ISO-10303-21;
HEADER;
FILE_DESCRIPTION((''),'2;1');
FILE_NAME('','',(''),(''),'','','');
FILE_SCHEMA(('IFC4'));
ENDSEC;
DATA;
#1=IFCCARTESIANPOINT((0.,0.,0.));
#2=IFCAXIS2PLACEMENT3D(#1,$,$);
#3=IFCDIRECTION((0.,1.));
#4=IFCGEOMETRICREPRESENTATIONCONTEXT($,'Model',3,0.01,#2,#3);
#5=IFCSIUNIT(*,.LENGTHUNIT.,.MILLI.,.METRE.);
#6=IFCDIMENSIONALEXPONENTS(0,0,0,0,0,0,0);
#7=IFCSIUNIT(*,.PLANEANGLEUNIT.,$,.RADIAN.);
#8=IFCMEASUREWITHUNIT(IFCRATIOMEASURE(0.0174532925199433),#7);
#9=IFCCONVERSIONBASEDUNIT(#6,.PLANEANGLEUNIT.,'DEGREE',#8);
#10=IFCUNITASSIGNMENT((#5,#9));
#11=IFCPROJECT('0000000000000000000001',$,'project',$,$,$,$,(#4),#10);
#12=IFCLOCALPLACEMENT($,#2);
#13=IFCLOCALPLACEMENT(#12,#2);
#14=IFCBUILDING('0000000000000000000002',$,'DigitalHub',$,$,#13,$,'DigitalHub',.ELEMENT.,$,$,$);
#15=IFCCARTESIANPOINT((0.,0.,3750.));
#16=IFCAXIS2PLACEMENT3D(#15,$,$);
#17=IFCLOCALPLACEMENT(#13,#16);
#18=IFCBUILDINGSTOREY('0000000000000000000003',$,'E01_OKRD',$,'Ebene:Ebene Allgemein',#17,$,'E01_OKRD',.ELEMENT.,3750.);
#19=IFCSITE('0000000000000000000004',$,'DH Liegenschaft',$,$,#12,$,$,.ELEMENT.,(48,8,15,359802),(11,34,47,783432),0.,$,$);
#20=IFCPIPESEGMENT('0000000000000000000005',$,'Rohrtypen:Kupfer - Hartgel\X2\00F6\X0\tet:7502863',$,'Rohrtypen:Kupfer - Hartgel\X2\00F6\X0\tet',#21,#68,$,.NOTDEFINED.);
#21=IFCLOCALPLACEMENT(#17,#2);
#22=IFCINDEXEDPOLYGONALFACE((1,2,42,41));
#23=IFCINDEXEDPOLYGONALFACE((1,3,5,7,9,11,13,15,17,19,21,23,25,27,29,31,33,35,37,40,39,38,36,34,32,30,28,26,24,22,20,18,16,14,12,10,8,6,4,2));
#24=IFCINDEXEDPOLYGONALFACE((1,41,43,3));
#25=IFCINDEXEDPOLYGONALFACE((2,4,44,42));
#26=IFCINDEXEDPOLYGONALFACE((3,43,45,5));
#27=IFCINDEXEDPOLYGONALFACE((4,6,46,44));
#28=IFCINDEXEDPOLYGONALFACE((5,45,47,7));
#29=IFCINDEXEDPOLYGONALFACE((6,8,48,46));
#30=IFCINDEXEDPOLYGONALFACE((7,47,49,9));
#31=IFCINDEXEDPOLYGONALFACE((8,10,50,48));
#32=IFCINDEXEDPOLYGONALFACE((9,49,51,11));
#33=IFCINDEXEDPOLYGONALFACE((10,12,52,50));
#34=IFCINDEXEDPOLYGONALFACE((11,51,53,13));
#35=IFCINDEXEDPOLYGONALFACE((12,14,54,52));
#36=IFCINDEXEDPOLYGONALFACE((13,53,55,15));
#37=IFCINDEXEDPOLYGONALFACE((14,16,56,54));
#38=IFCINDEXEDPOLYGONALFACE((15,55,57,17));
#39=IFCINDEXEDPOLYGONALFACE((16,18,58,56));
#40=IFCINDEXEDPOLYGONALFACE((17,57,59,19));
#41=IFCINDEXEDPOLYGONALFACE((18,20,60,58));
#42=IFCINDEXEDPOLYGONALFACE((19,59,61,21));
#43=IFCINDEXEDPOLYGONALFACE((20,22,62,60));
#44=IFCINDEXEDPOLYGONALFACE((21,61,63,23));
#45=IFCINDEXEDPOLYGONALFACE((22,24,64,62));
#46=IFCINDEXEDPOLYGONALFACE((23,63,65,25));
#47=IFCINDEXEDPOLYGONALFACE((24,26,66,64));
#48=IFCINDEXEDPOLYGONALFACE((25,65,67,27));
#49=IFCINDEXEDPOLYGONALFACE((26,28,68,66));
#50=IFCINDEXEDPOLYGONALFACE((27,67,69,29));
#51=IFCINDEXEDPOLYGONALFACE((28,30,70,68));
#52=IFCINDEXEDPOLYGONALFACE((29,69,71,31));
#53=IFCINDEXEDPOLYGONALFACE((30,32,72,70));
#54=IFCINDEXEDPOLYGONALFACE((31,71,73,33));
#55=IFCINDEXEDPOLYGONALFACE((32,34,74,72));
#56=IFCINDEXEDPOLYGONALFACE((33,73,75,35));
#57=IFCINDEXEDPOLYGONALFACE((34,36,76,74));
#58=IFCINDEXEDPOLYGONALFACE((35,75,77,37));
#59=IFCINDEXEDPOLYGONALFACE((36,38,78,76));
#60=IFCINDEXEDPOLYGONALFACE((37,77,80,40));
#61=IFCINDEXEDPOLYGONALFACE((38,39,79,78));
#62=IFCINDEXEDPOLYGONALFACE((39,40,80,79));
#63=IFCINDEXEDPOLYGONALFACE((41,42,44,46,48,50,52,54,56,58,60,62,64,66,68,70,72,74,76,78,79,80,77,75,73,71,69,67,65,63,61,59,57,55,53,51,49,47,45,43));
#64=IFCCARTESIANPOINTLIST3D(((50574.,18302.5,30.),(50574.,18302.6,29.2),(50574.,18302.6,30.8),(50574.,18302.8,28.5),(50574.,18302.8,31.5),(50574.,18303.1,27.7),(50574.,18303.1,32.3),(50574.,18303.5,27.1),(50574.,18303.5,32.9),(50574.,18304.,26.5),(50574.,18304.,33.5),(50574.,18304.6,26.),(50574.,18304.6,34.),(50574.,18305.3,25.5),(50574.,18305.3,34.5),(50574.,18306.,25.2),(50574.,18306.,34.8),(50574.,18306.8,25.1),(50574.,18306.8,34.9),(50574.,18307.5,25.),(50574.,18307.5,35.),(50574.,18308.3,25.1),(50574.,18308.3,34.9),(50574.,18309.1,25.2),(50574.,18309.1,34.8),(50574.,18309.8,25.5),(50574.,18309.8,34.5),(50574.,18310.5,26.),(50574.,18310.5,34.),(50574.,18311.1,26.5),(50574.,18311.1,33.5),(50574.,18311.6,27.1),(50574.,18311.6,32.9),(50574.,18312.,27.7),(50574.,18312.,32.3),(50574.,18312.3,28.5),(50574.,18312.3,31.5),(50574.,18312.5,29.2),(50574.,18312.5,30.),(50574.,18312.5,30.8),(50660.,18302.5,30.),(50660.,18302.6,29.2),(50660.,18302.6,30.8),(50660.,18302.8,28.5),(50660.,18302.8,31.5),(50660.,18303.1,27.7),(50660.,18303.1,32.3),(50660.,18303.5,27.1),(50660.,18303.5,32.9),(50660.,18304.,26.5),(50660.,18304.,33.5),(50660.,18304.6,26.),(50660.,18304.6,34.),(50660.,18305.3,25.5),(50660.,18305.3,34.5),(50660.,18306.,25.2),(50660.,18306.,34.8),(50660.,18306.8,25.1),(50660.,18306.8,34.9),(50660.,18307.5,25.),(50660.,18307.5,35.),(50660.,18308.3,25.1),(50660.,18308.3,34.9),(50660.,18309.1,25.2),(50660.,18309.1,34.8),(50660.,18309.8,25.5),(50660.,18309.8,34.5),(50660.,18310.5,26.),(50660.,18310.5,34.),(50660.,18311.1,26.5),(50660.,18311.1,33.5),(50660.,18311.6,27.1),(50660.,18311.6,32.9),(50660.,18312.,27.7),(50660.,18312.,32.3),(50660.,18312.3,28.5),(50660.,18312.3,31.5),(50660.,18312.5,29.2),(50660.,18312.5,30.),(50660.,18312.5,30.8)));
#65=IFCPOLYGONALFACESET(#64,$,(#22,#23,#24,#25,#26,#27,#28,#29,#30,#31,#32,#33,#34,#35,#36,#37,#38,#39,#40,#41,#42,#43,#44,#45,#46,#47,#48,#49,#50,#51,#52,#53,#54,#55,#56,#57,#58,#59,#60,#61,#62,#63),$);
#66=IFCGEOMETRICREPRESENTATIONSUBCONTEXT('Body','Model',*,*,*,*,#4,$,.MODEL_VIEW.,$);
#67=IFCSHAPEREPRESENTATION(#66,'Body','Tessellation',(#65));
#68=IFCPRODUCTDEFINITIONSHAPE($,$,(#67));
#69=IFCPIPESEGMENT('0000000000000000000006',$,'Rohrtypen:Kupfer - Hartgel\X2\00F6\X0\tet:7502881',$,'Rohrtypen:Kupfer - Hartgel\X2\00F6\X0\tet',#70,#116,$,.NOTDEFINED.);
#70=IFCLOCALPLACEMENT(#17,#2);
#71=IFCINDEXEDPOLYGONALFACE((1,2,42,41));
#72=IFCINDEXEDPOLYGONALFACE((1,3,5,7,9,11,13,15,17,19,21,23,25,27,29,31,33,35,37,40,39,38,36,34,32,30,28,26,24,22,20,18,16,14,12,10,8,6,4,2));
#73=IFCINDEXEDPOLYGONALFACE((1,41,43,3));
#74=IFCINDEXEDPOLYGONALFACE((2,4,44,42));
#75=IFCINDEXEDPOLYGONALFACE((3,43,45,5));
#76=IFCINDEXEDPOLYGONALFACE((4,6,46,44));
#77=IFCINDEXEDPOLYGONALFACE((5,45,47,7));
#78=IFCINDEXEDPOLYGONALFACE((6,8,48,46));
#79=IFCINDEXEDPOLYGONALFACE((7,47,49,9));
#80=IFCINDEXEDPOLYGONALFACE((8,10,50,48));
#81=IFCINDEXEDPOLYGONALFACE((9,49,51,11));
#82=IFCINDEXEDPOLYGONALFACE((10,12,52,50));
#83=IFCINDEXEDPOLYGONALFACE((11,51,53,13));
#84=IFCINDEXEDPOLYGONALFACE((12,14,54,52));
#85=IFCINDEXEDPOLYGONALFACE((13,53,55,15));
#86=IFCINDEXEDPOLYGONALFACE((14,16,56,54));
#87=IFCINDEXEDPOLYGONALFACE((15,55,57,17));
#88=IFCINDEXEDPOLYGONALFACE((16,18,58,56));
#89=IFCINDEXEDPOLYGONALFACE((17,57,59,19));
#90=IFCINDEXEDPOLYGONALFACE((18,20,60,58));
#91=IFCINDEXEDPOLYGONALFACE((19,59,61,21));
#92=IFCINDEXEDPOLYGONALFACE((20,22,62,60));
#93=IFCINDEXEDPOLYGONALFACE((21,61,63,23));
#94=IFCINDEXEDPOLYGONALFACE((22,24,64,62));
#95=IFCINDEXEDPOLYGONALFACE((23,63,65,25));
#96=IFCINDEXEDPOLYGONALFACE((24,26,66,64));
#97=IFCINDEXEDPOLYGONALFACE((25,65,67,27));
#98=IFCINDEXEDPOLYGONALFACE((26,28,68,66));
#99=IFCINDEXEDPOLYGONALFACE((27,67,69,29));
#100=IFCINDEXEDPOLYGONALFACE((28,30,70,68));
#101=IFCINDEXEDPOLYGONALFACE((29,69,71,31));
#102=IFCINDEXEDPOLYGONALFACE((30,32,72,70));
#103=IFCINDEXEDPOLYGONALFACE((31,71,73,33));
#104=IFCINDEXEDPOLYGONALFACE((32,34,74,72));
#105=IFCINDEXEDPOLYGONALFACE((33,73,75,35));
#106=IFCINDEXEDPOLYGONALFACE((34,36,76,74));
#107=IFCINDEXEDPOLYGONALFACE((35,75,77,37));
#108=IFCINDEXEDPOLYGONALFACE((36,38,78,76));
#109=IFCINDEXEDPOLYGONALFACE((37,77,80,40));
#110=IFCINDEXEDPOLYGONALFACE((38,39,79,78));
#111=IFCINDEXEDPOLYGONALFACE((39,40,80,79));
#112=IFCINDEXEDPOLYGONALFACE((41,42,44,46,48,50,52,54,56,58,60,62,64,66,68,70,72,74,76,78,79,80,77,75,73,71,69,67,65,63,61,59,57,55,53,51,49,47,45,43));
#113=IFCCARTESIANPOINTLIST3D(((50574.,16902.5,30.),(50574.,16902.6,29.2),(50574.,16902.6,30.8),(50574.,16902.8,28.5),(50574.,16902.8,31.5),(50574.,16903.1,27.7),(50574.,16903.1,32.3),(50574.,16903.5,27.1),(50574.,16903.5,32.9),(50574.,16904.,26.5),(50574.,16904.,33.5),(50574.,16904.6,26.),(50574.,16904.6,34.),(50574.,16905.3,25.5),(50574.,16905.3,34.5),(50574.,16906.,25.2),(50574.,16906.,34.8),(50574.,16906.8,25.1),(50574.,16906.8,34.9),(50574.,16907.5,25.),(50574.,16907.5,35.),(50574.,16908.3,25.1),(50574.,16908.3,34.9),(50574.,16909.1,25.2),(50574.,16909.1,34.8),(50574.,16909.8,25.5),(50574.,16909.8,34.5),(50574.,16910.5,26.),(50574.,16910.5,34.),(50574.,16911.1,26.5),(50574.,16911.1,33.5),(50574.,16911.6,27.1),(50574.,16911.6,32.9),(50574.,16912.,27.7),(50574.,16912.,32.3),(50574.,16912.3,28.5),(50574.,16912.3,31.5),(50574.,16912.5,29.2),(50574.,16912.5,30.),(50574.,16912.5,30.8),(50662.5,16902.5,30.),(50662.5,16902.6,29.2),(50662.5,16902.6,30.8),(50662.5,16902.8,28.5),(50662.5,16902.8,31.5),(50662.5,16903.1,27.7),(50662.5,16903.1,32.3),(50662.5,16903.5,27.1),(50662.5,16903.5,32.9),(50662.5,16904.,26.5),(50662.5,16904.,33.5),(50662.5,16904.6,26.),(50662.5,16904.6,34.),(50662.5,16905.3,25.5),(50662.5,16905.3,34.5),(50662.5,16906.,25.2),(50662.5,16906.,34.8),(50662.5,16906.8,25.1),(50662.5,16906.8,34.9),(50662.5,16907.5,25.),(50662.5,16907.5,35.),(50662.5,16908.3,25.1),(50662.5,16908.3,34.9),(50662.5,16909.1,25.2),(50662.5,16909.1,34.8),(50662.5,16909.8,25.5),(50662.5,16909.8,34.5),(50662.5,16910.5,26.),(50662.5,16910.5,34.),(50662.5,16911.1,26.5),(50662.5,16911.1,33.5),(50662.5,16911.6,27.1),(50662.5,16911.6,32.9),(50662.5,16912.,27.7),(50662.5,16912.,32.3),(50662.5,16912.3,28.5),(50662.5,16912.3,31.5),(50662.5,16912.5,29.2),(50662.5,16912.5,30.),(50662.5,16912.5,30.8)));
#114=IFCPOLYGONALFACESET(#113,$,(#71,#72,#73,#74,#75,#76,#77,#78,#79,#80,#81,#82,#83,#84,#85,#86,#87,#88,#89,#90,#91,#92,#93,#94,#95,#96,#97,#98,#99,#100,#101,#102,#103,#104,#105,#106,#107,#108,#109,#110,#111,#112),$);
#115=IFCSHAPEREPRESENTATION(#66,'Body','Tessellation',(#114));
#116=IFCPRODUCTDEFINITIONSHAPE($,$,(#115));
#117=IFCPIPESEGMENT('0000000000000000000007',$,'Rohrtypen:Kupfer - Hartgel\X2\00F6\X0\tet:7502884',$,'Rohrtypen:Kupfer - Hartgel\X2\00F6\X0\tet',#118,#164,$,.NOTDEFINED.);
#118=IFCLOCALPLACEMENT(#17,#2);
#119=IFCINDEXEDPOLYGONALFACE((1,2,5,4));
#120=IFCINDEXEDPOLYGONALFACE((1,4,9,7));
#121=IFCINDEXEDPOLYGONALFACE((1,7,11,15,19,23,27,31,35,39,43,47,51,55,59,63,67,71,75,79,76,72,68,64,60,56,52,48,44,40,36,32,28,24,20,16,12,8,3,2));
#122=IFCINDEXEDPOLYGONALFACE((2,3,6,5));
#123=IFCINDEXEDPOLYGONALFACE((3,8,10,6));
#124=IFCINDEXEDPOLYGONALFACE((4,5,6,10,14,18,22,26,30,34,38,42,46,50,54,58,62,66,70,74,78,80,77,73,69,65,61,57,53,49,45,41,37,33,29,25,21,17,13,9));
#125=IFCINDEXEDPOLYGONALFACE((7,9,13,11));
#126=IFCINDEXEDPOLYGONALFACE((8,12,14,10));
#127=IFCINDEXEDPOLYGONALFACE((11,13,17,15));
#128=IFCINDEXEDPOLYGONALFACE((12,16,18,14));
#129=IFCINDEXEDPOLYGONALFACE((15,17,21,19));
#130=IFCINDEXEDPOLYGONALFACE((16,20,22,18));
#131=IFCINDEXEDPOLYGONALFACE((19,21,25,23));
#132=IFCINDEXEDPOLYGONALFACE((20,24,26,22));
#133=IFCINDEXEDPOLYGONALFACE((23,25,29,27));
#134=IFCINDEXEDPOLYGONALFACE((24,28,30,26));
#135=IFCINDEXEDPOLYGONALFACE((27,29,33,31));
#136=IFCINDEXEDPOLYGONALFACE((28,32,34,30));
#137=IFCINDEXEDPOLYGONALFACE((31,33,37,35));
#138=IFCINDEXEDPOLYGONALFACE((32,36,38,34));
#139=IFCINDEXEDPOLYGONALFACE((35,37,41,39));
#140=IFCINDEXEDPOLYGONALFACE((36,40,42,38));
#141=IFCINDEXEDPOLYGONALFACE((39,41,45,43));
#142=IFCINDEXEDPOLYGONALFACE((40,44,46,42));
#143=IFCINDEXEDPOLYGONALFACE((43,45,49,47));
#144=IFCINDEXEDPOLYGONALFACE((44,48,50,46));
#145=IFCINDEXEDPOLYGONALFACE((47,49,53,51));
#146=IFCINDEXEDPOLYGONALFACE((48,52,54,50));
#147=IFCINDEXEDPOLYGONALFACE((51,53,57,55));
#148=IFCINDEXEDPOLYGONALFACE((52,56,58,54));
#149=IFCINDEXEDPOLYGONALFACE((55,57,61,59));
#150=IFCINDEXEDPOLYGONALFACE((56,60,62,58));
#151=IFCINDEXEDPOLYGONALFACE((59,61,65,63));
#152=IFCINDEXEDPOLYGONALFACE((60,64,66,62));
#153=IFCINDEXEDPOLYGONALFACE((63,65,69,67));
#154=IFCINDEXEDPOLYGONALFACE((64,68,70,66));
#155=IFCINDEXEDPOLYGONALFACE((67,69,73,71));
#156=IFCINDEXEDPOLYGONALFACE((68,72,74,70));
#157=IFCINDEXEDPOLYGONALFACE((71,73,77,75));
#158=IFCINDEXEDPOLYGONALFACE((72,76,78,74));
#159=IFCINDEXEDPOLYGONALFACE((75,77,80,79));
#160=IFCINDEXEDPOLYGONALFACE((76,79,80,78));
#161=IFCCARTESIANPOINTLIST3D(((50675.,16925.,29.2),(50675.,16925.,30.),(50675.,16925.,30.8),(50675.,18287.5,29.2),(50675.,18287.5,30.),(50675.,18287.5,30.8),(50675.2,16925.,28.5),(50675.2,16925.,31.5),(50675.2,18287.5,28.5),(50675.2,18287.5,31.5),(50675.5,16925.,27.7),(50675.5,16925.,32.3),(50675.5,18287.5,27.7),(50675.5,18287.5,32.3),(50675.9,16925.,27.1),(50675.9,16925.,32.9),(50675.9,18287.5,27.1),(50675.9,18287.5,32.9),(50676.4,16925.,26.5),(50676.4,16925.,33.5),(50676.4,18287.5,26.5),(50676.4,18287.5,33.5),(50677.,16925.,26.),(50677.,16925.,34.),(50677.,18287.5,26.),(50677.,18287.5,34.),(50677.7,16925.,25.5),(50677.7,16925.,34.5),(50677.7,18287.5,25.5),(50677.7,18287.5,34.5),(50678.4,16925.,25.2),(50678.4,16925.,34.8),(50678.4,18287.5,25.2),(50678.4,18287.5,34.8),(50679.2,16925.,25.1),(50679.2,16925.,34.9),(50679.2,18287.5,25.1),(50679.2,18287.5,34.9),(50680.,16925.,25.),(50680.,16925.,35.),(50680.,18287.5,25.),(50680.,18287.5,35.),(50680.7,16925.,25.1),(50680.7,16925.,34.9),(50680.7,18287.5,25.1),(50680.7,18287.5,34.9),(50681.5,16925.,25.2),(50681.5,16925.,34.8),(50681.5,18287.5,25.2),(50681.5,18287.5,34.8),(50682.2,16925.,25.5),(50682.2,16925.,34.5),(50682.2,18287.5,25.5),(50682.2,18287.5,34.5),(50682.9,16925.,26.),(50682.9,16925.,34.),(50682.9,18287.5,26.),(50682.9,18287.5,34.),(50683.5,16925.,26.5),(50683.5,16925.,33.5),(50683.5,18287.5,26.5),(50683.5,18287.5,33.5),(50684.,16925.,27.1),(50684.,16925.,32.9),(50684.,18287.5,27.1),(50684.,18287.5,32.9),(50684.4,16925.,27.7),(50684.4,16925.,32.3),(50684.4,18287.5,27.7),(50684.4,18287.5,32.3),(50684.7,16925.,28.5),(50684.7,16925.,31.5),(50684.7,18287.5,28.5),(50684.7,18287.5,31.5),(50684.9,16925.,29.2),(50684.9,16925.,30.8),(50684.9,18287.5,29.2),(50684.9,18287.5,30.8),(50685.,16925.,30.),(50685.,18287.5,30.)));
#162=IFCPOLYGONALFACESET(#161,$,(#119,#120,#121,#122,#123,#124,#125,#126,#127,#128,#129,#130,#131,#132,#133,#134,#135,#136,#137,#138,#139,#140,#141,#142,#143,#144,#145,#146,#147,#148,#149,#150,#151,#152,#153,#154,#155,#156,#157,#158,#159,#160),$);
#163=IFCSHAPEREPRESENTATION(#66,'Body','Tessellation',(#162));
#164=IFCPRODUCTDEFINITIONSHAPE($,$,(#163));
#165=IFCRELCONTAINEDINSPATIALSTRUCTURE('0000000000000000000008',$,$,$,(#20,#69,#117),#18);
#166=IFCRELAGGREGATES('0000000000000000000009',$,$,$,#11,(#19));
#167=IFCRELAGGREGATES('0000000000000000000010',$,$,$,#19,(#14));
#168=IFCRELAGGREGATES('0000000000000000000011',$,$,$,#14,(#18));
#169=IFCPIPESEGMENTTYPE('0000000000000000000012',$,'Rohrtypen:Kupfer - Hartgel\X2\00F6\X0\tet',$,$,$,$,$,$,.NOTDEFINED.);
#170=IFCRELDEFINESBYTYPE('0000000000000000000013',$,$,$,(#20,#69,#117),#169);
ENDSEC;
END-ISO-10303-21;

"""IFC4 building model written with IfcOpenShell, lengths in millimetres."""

from ifc_helpers import new_model, entity, si_unit, converted_unit, direction, frame, origin, place, context, subcontext, project, spatial, indexed_curve, outline, extrude, type_object, element, save


model = new_model("IFC4")

# Units and contexts
model_context = context("Model", 3, precision=0.01, world=origin(), true_north=direction((0.0, 1.0)))
body_context = subcontext(model_context, "Body", "Model", "MODEL_VIEW")
ifc_project = project(units=[si_unit("LENGTHUNIT", "METRE", prefix="MILLI"), converted_unit("PLANEANGLEUNIT", "DEGREE", entity("IfcRatioMeasure", 0.0174532925199433), si_unit("PLANEANGLEUNIT", "RADIAN"), dimensions=[0, 0, 0, 0, 0, 0, 0])], contexts=[model_context])

# Site, building, storey
site_placement = place(None, origin())
site = spatial("IfcSite", under=ifc_project, at=site_placement, Name="DH Liegenschaft", CompositionType="ELEMENT", RefLatitude=(48, 8, 15, 359802), RefLongitude=(11, 34, 47, 783432), RefElevation=0.0)
building_placement = place(site_placement, origin())
building = spatial("IfcBuilding", under=site, at=building_placement, Name="DigitalHub", LongName="DigitalHub", CompositionType="ELEMENT")
storey_placement = place(building_placement, frame((0.0, 0.0, 3750.0)))
storey = spatial("IfcBuildingStorey", under=building, at=storey_placement, Name="E01_OKRD", ObjectType="Ebene:Ebene Allgemein", LongName="E01_OKRD", CompositionType="ELEMENT", Elevation=3750.0)

# Pipe segments
pipe_segment_type = type_object("IfcPipeSegmentType", Name="Rohrtypen:Kupfer - Hartgelötet", PredefinedType="NOTDEFINED")
pipe_segment_1_placement = place(storey_placement, frame((50574.0, 18300.9, 23.4)))
element("IfcPipeSegment", 1, at=pipe_segment_1_placement, inside=storey, type_object=pipe_segment_type, Name="Rohrtypen:Kupfer - Hartgelötet:7502863", ObjectType="Rohrtypen:Kupfer - Hartgelötet", PredefinedType="NOTDEFINED", context=body_context, shape_type="SweptSolid", body=[
    extrude(outline(indexed_curve([(5.0, 0.0), (4.9, 0.8), (4.8, 1.5), (4.5, 2.3), (4.0, 2.9), (3.5, 3.5), (2.9, 4.0), (2.3, 4.5), (1.5, 4.8), (0.8, 4.9), (0.0, 5.0), (-0.8, 4.9), (-1.5, 4.8), (-2.3, 4.5), (-2.9, 4.0), (-3.5, 3.5), (-4.0, 2.9), (-4.5, 2.3), (-4.8, 1.5), (-4.9, 0.8), (-5.0, 0.0), (-4.9, -0.8), (-4.8, -1.5), (-4.5, -2.3), (-4.0, -2.9), (-3.5, -3.5), (-2.9, -4.0), (-2.3, -4.5), (-1.5, -4.8), (-0.8, -4.9), (0.0, -5.0), (0.8, -4.9), (1.5, -4.8), (2.3, -4.5), (2.9, -4.0), (3.5, -3.5), (4.0, -2.9), (4.5, -2.3), (4.8, -1.5), (4.9, -0.8), (5.0, 0.0)], self_intersect=False)), frame((0.0, 6.6, 6.6), z_axis=(1.0, 0.0, 0.0), x_axis=(0.0, -1.0, 0.0)), (0.0, 0.0, 1.0), 86.0),
])
pipe_segment_2_placement = place(storey_placement, frame((50574.0, 16900.9, 23.4)))
element("IfcPipeSegment", 2, at=pipe_segment_2_placement, inside=storey, type_object=pipe_segment_type, Name="Rohrtypen:Kupfer - Hartgelötet:7502881", ObjectType="Rohrtypen:Kupfer - Hartgelötet", PredefinedType="NOTDEFINED", context=body_context, shape_type="SweptSolid", body=[
    extrude(outline(indexed_curve([(5.0, 0.0), (4.9, 0.8), (4.8, 1.5), (4.5, 2.3), (4.0, 2.9), (3.5, 3.5), (2.9, 4.0), (2.3, 4.5), (1.5, 4.8), (0.8, 4.9), (0.0, 5.0), (-0.8, 4.9), (-1.5, 4.8), (-2.3, 4.5), (-2.9, 4.0), (-3.5, 3.5), (-4.0, 2.9), (-4.5, 2.3), (-4.8, 1.5), (-4.9, 0.8), (-5.0, 0.0), (-4.9, -0.8), (-4.8, -1.5), (-4.5, -2.3), (-4.0, -2.9), (-3.5, -3.5), (-2.9, -4.0), (-2.3, -4.5), (-1.5, -4.8), (-0.8, -4.9), (0.0, -5.0), (0.8, -4.9), (1.5, -4.8), (2.3, -4.5), (2.9, -4.0), (3.5, -3.5), (4.0, -2.9), (4.5, -2.3), (4.8, -1.5), (4.9, -0.8), (5.0, 0.0)], self_intersect=False)), frame((0.0, 6.6, 6.6), z_axis=(1.0, 0.0, 0.0), x_axis=(0.0, 1.0, 0.0)), (0.0, 0.0, 1.0), 88.6),
])
pipe_segment_3_placement = place(storey_placement, frame((50673.4, 16925.0, 23.4)))
element("IfcPipeSegment", 3, at=pipe_segment_3_placement, inside=storey, type_object=pipe_segment_type, Name="Rohrtypen:Kupfer - Hartgelötet:7502884", ObjectType="Rohrtypen:Kupfer - Hartgelötet", PredefinedType="NOTDEFINED", context=body_context, shape_type="SweptSolid", body=[
    extrude(outline(indexed_curve([(5.0, 0.0), (4.9, 0.8), (4.8, 1.5), (4.5, 2.3), (4.0, 2.9), (3.5, 3.5), (2.9, 4.0), (2.3, 4.5), (1.5, 4.8), (0.8, 4.9), (0.0, 5.0), (-0.8, 4.9), (-1.5, 4.8), (-2.3, 4.5), (-2.9, 4.0), (-3.5, 3.5), (-4.0, 2.9), (-4.5, 2.3), (-4.8, 1.5), (-4.9, 0.8), (-5.0, 0.0), (-4.9, -0.8), (-4.8, -1.5), (-4.5, -2.3), (-4.0, -2.9), (-3.5, -3.5), (-2.9, -4.0), (-2.3, -4.5), (-1.5, -4.8), (-0.8, -4.9), (0.0, -5.0), (0.8, -4.9), (1.5, -4.8), (2.3, -4.5), (2.9, -4.0), (3.5, -3.5), (4.0, -2.9), (4.5, -2.3), (4.8, -1.5), (4.9, -0.8), (5.0, 0.0)], self_intersect=False)), frame((6.6, 0.0, 6.6), z_axis=(0.0, 1.0, 0.0), x_axis=(-1.0, 0.0, 0.0)), (0.0, 0.0, 1.0), 1362.6),
])

save(model, "model.ifc")
